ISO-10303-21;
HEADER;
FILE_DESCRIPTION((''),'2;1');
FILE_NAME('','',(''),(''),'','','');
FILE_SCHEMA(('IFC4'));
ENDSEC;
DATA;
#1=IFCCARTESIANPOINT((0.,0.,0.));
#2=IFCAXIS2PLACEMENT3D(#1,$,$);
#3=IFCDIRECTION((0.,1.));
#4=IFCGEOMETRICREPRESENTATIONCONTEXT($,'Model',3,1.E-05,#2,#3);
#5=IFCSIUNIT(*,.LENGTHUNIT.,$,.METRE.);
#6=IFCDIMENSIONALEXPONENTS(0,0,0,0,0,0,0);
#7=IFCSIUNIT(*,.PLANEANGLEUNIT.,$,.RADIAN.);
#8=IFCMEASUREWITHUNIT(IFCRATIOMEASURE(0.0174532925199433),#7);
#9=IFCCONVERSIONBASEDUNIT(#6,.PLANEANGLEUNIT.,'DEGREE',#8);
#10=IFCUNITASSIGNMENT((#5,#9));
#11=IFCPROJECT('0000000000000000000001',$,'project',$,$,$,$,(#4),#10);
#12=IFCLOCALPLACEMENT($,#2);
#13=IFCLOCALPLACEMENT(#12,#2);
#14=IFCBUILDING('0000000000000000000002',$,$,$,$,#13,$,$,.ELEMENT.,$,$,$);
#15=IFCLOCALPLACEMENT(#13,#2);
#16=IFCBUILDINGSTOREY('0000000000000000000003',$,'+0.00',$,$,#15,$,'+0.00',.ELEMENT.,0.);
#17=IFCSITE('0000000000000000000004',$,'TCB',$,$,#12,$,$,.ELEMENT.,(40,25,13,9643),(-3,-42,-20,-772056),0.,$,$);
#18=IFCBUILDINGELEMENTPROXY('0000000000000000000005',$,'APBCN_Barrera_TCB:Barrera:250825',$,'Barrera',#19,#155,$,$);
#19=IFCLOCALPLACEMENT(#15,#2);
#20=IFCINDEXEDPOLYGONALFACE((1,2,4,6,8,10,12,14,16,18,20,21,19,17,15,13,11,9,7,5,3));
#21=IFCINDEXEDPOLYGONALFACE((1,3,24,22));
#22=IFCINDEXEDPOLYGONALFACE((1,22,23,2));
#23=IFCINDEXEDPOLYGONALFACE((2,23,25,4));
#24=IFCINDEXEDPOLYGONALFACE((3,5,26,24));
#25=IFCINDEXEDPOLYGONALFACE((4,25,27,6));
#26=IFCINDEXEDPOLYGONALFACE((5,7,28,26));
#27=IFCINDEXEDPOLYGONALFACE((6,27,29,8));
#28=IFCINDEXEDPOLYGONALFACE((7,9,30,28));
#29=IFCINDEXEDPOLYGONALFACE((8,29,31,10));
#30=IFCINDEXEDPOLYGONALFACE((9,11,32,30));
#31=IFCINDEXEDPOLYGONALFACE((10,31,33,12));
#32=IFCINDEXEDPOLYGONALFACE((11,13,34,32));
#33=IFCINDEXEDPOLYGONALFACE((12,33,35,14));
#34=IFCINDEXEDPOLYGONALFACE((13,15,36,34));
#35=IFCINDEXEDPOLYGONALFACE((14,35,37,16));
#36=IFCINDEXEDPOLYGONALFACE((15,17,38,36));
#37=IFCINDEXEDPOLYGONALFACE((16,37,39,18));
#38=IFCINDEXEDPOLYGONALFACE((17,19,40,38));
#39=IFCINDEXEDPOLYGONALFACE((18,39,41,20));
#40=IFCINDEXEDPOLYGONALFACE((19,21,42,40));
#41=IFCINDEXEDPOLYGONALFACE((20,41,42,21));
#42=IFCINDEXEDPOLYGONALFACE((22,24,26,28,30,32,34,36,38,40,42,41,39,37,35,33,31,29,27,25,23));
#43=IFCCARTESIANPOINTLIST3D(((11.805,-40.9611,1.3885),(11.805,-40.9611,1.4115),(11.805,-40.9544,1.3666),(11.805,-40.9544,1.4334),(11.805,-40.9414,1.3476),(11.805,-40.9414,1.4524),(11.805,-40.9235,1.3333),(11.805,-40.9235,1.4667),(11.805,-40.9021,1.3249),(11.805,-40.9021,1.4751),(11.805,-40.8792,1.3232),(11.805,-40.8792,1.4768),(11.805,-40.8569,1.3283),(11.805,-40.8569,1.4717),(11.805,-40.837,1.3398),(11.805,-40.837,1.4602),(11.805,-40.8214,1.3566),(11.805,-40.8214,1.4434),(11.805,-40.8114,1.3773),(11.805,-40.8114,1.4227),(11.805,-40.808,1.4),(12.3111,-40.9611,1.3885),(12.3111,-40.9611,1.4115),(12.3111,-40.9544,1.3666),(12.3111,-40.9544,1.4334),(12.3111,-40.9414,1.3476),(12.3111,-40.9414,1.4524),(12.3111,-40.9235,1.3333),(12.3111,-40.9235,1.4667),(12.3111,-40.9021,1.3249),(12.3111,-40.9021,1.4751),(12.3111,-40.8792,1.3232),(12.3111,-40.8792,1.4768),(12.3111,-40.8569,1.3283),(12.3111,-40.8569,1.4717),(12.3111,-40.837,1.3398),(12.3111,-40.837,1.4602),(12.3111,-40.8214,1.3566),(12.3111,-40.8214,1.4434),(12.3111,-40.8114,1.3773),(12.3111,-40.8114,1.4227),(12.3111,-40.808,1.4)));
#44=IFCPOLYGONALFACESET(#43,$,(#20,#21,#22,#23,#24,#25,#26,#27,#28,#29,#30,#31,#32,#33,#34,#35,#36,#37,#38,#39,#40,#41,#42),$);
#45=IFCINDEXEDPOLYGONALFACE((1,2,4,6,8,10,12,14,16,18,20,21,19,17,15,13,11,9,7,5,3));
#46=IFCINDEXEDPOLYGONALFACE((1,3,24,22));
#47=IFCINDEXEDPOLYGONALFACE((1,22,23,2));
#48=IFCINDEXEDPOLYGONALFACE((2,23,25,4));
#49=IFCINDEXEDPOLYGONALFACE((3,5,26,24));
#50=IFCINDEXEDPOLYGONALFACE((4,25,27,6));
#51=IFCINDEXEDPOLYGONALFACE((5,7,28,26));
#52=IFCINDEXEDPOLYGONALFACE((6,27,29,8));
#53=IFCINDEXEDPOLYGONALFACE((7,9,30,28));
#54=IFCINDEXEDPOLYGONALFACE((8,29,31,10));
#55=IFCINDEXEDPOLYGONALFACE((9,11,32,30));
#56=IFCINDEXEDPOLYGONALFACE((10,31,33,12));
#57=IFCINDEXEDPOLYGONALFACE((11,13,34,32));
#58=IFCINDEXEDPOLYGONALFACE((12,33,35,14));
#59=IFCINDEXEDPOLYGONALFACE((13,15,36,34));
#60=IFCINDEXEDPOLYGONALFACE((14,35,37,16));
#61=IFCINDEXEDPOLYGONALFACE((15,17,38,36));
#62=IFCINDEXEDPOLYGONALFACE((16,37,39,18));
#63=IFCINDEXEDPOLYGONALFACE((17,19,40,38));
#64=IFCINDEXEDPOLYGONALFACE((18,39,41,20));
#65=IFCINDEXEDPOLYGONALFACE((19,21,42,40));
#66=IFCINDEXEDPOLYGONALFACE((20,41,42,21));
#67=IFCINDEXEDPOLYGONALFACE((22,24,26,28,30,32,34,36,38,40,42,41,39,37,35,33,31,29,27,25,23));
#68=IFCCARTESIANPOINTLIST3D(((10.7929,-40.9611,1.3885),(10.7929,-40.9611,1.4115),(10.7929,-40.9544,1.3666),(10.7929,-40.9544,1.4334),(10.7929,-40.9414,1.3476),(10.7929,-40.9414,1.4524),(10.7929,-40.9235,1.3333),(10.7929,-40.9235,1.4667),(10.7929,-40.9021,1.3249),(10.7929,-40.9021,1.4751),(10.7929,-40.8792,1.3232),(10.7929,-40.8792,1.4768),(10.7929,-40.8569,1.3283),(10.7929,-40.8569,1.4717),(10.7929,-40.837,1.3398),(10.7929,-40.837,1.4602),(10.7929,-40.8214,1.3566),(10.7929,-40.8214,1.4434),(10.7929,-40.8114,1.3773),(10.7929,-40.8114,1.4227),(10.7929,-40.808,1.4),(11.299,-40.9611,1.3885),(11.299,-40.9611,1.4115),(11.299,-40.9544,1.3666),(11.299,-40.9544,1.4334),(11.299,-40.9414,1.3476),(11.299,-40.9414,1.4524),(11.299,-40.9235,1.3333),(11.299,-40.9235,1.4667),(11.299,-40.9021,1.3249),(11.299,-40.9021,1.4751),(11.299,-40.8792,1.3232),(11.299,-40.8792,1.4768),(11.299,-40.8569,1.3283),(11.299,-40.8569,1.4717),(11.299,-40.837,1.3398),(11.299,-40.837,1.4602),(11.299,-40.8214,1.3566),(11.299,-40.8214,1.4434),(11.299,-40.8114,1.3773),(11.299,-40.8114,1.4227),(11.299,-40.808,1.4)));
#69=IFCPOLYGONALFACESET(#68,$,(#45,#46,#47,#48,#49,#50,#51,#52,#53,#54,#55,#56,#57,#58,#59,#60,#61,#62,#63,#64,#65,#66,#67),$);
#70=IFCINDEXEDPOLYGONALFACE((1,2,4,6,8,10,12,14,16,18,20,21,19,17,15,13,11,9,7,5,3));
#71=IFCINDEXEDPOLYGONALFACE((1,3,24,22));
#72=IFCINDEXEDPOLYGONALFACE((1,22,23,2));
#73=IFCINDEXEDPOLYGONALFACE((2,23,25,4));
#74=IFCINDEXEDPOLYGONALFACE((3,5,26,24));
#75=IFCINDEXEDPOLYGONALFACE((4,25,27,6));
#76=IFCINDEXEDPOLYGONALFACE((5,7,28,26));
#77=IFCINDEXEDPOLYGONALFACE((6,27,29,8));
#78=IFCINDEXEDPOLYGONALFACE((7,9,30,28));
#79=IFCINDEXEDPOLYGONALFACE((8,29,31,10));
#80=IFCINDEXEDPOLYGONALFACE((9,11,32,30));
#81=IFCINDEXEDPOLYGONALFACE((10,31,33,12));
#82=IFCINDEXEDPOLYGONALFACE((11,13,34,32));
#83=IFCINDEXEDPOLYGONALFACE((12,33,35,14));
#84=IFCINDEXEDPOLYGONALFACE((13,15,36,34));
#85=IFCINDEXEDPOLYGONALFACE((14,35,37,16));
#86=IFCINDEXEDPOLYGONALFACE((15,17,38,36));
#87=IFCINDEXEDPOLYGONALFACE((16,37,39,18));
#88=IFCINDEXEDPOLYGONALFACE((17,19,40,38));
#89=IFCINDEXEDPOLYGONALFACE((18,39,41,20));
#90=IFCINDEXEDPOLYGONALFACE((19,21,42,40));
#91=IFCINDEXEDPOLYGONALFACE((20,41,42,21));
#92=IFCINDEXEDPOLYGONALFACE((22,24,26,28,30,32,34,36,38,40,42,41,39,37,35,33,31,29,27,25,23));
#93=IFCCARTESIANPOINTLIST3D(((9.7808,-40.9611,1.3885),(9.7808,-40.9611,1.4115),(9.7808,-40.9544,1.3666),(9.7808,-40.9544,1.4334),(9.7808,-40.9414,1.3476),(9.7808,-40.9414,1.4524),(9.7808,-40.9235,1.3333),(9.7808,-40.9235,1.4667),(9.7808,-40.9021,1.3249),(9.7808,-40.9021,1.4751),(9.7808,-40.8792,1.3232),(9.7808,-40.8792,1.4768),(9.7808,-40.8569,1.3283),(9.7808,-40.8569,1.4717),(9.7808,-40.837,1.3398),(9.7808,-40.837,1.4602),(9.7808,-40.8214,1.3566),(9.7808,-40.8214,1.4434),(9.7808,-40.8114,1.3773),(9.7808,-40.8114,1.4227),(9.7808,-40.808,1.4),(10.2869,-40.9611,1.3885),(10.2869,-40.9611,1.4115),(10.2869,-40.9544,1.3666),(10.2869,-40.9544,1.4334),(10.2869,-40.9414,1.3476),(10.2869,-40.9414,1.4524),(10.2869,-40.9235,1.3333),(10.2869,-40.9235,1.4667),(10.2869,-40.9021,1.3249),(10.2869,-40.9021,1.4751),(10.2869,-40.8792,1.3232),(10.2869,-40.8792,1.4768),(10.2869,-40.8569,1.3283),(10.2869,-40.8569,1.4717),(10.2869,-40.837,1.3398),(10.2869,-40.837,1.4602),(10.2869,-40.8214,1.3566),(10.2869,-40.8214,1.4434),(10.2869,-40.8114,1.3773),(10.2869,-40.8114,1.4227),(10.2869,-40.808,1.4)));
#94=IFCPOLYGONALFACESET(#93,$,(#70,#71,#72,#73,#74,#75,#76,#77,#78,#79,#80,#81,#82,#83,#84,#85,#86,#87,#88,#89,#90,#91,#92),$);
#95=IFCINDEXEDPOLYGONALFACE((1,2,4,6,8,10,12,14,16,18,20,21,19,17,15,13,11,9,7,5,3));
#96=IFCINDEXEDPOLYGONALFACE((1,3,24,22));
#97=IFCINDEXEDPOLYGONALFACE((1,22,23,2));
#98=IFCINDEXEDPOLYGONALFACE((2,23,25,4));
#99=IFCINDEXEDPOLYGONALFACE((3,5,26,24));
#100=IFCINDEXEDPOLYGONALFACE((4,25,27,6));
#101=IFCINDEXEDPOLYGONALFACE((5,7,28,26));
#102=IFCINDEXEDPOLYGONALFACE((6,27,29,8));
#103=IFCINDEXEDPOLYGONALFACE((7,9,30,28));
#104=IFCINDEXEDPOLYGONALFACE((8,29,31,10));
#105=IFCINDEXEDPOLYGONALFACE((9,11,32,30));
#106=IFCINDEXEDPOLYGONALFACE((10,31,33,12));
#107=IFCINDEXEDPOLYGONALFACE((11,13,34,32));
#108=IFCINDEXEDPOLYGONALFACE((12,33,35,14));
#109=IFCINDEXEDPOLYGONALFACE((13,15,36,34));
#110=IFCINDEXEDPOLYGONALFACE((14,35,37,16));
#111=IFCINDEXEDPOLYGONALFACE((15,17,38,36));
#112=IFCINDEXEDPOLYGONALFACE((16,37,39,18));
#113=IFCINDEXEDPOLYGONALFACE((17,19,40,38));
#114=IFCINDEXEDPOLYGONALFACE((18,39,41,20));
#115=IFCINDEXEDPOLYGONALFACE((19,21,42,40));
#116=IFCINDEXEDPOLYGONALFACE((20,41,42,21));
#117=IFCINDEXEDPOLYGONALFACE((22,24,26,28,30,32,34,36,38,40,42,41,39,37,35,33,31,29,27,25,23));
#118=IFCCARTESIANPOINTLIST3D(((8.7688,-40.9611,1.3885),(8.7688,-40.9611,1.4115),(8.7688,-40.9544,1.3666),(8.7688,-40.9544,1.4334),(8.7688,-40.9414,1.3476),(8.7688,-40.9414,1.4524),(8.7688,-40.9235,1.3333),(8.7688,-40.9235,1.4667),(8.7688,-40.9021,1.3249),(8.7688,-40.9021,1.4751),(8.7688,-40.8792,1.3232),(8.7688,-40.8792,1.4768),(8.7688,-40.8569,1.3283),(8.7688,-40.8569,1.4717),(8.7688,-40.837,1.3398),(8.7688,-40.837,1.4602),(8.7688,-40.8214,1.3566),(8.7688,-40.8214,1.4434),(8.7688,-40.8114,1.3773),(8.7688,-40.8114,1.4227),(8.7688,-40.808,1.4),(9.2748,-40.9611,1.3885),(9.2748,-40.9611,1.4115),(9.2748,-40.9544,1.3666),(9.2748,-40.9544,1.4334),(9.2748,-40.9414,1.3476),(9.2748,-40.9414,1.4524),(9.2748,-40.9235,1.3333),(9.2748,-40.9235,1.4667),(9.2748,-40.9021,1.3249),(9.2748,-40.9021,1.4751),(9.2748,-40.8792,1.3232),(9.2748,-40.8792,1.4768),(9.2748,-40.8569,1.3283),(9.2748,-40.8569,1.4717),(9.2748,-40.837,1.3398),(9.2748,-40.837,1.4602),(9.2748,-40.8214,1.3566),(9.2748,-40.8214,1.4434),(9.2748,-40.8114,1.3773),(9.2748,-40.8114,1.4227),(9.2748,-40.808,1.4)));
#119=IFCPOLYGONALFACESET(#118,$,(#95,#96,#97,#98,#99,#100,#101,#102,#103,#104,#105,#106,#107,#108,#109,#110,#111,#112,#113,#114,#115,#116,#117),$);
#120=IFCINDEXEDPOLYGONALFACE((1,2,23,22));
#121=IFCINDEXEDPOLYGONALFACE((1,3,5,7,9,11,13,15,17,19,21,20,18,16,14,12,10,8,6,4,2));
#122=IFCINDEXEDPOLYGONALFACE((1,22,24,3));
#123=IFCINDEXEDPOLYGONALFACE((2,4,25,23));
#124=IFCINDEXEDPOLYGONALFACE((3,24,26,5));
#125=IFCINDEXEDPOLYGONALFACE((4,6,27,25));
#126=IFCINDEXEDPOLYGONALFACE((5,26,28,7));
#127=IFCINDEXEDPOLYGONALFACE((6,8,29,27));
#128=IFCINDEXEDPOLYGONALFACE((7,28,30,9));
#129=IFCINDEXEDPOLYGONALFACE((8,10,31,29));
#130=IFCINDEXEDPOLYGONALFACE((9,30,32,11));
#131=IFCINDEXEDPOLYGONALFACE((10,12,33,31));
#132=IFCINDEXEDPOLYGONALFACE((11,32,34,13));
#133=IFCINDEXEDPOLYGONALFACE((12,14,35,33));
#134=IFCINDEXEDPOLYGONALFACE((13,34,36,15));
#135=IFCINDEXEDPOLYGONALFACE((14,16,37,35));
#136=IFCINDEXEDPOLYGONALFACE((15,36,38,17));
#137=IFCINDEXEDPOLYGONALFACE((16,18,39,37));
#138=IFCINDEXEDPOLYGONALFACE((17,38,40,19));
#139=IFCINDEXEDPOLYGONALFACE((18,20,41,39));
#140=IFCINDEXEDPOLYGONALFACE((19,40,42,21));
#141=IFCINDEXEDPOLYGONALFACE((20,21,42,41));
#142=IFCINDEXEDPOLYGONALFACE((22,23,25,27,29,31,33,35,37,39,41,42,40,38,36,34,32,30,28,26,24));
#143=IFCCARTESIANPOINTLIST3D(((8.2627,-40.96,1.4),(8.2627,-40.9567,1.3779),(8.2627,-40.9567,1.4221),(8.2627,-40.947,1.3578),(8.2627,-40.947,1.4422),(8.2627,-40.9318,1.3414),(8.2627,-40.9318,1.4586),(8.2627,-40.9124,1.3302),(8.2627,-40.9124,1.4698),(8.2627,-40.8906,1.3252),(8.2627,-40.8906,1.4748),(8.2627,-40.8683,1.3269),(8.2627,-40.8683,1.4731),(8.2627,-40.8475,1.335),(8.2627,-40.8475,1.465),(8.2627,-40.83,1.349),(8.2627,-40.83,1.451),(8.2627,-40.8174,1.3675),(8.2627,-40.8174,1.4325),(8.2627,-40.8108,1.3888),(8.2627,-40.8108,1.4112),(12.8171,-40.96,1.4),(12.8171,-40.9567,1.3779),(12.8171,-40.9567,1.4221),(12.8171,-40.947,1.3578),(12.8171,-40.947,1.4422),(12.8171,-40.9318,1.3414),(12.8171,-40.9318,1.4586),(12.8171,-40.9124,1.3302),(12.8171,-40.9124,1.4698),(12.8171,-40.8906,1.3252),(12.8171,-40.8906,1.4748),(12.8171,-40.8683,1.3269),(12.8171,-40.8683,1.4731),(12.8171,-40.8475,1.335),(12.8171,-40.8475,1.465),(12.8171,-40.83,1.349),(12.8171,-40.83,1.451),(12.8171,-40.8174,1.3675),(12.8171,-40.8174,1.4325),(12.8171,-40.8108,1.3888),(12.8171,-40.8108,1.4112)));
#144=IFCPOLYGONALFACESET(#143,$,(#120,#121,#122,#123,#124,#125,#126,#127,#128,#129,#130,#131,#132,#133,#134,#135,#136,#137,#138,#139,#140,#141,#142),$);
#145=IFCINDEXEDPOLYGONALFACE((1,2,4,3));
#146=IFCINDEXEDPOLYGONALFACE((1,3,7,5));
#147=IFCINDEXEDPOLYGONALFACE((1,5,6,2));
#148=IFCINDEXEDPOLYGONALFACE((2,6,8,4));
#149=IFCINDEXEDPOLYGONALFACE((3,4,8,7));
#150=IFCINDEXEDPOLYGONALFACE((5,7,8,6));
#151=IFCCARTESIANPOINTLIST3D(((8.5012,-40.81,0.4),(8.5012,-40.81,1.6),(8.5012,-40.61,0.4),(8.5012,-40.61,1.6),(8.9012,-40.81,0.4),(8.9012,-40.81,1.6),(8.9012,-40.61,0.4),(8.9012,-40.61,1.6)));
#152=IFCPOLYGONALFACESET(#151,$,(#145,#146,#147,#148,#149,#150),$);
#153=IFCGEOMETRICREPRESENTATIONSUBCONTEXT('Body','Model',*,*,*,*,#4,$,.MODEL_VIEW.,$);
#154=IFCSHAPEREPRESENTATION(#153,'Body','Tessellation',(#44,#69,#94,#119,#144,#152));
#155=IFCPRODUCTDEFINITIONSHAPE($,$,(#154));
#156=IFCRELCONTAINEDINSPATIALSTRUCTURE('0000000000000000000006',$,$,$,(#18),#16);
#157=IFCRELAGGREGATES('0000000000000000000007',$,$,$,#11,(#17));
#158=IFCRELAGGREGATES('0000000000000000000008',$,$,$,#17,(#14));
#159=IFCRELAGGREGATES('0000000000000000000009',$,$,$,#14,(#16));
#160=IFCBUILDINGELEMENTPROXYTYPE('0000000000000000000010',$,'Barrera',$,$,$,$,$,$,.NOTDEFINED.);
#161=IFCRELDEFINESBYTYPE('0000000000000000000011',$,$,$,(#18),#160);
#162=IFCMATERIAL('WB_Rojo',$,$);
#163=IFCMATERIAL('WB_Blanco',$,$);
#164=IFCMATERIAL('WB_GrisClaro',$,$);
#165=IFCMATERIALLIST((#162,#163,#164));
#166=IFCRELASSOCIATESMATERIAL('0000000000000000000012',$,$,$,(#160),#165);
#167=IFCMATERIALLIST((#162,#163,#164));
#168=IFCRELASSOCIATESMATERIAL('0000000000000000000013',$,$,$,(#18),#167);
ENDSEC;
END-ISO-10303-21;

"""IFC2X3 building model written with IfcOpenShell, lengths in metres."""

from ifc_helpers import new_model, entity, si_unit, converted_unit, direction, frame, frame_2d, origin, place, context, subcontext, project, spatial, rectangle, circle, extrude, source, transform, mapped, material, material_list, type_object, type_shapes, element, save


model = new_model("IFC2X3")

# Units and contexts
model_context = context("Model", 3, precision=1e-05, world=origin(), true_north=direction((0.0, 1.0)))
body_context = subcontext(model_context, "Body", "Model", "MODEL_VIEW")
ifc_project = project(units=[si_unit("LENGTHUNIT", "METRE"), converted_unit("PLANEANGLEUNIT", "DEGREE", entity("IfcRatioMeasure", 0.0174532925199433), si_unit("PLANEANGLEUNIT", "RADIAN"), dimensions=[0, 0, 0, 0, 0, 0, 0])], contexts=[model_context])

# Site, building, storey
site_placement = place(None, origin())
site = spatial("IfcSite", under=ifc_project, at=site_placement, Name="TCB", CompositionType="ELEMENT", RefLatitude=(40, 25, 13, 9643), RefLongitude=(-3, -42, -20, -772056), RefElevation=0.0)
building_placement = place(site_placement, origin())
building = spatial("IfcBuilding", under=site, at=building_placement, CompositionType="ELEMENT")
storey_placement = place(building_placement, origin())
storey = spatial("IfcBuildingStorey", under=building, at=storey_placement, Name="+0.00", LongName="+0.00", CompositionType="ELEMENT", Elevation=0.0)

# Shared definitions
ifc_material_1 = material(Name="WB_Blanco")

# Shared definitions
ifc_material_2 = material(Name="WB_GrisClaro")

# Building element proxy
ifc_material_3 = material(Name="WB_Rojo")
ifc_material_list_1 = material_list([ifc_material_3, ifc_material_1, ifc_material_2])
building_element_proxy_type_1 = type_object("IfcBuildingElementProxyType", Name="Barrera", PredefinedType="NOTDEFINED", material=ifc_material_list_1)
shared_shape_1 = source(origin(), body_context, "Body", "SweptSolid", [
    extrude(circle(Radius=0.077, at=frame_2d((0.0, 0.0), x_axis=(1.0, 0.0))), frame((2.8039, -0.175, 1.0), z_axis=(1.0, 0.0, 0.0), x_axis=(0.0, 1.0, 0.0)), (0.0, 0.0, 1.0), 0.506),
    extrude(circle(Radius=0.077, at=frame_2d((0.0, 0.0), x_axis=(1.0, 0.0))), frame((1.7918, -0.175, 1.0), z_axis=(1.0, 0.0, 0.0), x_axis=(0.0, 1.0, 0.0)), (0.0, 0.0, 1.0), 0.506),
    extrude(circle(Radius=0.077, at=frame_2d((0.0, 0.0), x_axis=(1.0, 0.0))), frame((0.7797, -0.175, 1.0), z_axis=(1.0, 0.0, 0.0), x_axis=(0.0, 1.0, 0.0)), (0.0, 0.0, 1.0), 0.506),
    extrude(circle(Radius=0.077, at=frame_2d((0.0, 0.0), x_axis=(1.0, 0.0))), frame((-0.2324, -0.175, 1.0), z_axis=(1.0, 0.0, 0.0), x_axis=(0.0, 1.0, 0.0)), (0.0, 0.0, 1.0), 0.506),
    extrude(circle(Radius=0.075, at=frame_2d((0.0, 0.0), x_axis=(1.0, 0.0))), frame((-0.7385, -0.175, 1.0), z_axis=(1.0, 0.0, 0.0), x_axis=(0.0, -1.0, 0.0)), (0.0, 0.0, 1.0), 4.5544),
    extrude(rectangle(XDim=0.2, YDim=0.4, at=frame_2d((0.0, 0.0), x_axis=(1.0, 0.0))), frame((-0.3, 0.0, 0.0), z_axis=(0.0, 0.0, 1.0), x_axis=(0.0, -1.0, 0.0)), (0.0, 0.0, 1.0), 1.2),
])
type_shapes(building_element_proxy_type_1, [shared_shape_1])
ifc_material_list_2 = material_list([ifc_material_3, ifc_material_1, ifc_material_2])
proxy_1_placement = place(storey_placement, frame((9.0012, -40.71, 0.4)))
element("IfcBuildingElementProxy", 1, at=proxy_1_placement, inside=storey, type_object=building_element_proxy_type_1, material=ifc_material_list_2, Name="APBCN_Barrera_TCB:Barrera:250825", ObjectType="Barrera", context=body_context, shape_type="MappedRepresentation", body=[
    mapped(shared_shape_1, transform((0.0, 0.0, 0.0), scale=1.0)),
])

save(model, "model.ifc")
